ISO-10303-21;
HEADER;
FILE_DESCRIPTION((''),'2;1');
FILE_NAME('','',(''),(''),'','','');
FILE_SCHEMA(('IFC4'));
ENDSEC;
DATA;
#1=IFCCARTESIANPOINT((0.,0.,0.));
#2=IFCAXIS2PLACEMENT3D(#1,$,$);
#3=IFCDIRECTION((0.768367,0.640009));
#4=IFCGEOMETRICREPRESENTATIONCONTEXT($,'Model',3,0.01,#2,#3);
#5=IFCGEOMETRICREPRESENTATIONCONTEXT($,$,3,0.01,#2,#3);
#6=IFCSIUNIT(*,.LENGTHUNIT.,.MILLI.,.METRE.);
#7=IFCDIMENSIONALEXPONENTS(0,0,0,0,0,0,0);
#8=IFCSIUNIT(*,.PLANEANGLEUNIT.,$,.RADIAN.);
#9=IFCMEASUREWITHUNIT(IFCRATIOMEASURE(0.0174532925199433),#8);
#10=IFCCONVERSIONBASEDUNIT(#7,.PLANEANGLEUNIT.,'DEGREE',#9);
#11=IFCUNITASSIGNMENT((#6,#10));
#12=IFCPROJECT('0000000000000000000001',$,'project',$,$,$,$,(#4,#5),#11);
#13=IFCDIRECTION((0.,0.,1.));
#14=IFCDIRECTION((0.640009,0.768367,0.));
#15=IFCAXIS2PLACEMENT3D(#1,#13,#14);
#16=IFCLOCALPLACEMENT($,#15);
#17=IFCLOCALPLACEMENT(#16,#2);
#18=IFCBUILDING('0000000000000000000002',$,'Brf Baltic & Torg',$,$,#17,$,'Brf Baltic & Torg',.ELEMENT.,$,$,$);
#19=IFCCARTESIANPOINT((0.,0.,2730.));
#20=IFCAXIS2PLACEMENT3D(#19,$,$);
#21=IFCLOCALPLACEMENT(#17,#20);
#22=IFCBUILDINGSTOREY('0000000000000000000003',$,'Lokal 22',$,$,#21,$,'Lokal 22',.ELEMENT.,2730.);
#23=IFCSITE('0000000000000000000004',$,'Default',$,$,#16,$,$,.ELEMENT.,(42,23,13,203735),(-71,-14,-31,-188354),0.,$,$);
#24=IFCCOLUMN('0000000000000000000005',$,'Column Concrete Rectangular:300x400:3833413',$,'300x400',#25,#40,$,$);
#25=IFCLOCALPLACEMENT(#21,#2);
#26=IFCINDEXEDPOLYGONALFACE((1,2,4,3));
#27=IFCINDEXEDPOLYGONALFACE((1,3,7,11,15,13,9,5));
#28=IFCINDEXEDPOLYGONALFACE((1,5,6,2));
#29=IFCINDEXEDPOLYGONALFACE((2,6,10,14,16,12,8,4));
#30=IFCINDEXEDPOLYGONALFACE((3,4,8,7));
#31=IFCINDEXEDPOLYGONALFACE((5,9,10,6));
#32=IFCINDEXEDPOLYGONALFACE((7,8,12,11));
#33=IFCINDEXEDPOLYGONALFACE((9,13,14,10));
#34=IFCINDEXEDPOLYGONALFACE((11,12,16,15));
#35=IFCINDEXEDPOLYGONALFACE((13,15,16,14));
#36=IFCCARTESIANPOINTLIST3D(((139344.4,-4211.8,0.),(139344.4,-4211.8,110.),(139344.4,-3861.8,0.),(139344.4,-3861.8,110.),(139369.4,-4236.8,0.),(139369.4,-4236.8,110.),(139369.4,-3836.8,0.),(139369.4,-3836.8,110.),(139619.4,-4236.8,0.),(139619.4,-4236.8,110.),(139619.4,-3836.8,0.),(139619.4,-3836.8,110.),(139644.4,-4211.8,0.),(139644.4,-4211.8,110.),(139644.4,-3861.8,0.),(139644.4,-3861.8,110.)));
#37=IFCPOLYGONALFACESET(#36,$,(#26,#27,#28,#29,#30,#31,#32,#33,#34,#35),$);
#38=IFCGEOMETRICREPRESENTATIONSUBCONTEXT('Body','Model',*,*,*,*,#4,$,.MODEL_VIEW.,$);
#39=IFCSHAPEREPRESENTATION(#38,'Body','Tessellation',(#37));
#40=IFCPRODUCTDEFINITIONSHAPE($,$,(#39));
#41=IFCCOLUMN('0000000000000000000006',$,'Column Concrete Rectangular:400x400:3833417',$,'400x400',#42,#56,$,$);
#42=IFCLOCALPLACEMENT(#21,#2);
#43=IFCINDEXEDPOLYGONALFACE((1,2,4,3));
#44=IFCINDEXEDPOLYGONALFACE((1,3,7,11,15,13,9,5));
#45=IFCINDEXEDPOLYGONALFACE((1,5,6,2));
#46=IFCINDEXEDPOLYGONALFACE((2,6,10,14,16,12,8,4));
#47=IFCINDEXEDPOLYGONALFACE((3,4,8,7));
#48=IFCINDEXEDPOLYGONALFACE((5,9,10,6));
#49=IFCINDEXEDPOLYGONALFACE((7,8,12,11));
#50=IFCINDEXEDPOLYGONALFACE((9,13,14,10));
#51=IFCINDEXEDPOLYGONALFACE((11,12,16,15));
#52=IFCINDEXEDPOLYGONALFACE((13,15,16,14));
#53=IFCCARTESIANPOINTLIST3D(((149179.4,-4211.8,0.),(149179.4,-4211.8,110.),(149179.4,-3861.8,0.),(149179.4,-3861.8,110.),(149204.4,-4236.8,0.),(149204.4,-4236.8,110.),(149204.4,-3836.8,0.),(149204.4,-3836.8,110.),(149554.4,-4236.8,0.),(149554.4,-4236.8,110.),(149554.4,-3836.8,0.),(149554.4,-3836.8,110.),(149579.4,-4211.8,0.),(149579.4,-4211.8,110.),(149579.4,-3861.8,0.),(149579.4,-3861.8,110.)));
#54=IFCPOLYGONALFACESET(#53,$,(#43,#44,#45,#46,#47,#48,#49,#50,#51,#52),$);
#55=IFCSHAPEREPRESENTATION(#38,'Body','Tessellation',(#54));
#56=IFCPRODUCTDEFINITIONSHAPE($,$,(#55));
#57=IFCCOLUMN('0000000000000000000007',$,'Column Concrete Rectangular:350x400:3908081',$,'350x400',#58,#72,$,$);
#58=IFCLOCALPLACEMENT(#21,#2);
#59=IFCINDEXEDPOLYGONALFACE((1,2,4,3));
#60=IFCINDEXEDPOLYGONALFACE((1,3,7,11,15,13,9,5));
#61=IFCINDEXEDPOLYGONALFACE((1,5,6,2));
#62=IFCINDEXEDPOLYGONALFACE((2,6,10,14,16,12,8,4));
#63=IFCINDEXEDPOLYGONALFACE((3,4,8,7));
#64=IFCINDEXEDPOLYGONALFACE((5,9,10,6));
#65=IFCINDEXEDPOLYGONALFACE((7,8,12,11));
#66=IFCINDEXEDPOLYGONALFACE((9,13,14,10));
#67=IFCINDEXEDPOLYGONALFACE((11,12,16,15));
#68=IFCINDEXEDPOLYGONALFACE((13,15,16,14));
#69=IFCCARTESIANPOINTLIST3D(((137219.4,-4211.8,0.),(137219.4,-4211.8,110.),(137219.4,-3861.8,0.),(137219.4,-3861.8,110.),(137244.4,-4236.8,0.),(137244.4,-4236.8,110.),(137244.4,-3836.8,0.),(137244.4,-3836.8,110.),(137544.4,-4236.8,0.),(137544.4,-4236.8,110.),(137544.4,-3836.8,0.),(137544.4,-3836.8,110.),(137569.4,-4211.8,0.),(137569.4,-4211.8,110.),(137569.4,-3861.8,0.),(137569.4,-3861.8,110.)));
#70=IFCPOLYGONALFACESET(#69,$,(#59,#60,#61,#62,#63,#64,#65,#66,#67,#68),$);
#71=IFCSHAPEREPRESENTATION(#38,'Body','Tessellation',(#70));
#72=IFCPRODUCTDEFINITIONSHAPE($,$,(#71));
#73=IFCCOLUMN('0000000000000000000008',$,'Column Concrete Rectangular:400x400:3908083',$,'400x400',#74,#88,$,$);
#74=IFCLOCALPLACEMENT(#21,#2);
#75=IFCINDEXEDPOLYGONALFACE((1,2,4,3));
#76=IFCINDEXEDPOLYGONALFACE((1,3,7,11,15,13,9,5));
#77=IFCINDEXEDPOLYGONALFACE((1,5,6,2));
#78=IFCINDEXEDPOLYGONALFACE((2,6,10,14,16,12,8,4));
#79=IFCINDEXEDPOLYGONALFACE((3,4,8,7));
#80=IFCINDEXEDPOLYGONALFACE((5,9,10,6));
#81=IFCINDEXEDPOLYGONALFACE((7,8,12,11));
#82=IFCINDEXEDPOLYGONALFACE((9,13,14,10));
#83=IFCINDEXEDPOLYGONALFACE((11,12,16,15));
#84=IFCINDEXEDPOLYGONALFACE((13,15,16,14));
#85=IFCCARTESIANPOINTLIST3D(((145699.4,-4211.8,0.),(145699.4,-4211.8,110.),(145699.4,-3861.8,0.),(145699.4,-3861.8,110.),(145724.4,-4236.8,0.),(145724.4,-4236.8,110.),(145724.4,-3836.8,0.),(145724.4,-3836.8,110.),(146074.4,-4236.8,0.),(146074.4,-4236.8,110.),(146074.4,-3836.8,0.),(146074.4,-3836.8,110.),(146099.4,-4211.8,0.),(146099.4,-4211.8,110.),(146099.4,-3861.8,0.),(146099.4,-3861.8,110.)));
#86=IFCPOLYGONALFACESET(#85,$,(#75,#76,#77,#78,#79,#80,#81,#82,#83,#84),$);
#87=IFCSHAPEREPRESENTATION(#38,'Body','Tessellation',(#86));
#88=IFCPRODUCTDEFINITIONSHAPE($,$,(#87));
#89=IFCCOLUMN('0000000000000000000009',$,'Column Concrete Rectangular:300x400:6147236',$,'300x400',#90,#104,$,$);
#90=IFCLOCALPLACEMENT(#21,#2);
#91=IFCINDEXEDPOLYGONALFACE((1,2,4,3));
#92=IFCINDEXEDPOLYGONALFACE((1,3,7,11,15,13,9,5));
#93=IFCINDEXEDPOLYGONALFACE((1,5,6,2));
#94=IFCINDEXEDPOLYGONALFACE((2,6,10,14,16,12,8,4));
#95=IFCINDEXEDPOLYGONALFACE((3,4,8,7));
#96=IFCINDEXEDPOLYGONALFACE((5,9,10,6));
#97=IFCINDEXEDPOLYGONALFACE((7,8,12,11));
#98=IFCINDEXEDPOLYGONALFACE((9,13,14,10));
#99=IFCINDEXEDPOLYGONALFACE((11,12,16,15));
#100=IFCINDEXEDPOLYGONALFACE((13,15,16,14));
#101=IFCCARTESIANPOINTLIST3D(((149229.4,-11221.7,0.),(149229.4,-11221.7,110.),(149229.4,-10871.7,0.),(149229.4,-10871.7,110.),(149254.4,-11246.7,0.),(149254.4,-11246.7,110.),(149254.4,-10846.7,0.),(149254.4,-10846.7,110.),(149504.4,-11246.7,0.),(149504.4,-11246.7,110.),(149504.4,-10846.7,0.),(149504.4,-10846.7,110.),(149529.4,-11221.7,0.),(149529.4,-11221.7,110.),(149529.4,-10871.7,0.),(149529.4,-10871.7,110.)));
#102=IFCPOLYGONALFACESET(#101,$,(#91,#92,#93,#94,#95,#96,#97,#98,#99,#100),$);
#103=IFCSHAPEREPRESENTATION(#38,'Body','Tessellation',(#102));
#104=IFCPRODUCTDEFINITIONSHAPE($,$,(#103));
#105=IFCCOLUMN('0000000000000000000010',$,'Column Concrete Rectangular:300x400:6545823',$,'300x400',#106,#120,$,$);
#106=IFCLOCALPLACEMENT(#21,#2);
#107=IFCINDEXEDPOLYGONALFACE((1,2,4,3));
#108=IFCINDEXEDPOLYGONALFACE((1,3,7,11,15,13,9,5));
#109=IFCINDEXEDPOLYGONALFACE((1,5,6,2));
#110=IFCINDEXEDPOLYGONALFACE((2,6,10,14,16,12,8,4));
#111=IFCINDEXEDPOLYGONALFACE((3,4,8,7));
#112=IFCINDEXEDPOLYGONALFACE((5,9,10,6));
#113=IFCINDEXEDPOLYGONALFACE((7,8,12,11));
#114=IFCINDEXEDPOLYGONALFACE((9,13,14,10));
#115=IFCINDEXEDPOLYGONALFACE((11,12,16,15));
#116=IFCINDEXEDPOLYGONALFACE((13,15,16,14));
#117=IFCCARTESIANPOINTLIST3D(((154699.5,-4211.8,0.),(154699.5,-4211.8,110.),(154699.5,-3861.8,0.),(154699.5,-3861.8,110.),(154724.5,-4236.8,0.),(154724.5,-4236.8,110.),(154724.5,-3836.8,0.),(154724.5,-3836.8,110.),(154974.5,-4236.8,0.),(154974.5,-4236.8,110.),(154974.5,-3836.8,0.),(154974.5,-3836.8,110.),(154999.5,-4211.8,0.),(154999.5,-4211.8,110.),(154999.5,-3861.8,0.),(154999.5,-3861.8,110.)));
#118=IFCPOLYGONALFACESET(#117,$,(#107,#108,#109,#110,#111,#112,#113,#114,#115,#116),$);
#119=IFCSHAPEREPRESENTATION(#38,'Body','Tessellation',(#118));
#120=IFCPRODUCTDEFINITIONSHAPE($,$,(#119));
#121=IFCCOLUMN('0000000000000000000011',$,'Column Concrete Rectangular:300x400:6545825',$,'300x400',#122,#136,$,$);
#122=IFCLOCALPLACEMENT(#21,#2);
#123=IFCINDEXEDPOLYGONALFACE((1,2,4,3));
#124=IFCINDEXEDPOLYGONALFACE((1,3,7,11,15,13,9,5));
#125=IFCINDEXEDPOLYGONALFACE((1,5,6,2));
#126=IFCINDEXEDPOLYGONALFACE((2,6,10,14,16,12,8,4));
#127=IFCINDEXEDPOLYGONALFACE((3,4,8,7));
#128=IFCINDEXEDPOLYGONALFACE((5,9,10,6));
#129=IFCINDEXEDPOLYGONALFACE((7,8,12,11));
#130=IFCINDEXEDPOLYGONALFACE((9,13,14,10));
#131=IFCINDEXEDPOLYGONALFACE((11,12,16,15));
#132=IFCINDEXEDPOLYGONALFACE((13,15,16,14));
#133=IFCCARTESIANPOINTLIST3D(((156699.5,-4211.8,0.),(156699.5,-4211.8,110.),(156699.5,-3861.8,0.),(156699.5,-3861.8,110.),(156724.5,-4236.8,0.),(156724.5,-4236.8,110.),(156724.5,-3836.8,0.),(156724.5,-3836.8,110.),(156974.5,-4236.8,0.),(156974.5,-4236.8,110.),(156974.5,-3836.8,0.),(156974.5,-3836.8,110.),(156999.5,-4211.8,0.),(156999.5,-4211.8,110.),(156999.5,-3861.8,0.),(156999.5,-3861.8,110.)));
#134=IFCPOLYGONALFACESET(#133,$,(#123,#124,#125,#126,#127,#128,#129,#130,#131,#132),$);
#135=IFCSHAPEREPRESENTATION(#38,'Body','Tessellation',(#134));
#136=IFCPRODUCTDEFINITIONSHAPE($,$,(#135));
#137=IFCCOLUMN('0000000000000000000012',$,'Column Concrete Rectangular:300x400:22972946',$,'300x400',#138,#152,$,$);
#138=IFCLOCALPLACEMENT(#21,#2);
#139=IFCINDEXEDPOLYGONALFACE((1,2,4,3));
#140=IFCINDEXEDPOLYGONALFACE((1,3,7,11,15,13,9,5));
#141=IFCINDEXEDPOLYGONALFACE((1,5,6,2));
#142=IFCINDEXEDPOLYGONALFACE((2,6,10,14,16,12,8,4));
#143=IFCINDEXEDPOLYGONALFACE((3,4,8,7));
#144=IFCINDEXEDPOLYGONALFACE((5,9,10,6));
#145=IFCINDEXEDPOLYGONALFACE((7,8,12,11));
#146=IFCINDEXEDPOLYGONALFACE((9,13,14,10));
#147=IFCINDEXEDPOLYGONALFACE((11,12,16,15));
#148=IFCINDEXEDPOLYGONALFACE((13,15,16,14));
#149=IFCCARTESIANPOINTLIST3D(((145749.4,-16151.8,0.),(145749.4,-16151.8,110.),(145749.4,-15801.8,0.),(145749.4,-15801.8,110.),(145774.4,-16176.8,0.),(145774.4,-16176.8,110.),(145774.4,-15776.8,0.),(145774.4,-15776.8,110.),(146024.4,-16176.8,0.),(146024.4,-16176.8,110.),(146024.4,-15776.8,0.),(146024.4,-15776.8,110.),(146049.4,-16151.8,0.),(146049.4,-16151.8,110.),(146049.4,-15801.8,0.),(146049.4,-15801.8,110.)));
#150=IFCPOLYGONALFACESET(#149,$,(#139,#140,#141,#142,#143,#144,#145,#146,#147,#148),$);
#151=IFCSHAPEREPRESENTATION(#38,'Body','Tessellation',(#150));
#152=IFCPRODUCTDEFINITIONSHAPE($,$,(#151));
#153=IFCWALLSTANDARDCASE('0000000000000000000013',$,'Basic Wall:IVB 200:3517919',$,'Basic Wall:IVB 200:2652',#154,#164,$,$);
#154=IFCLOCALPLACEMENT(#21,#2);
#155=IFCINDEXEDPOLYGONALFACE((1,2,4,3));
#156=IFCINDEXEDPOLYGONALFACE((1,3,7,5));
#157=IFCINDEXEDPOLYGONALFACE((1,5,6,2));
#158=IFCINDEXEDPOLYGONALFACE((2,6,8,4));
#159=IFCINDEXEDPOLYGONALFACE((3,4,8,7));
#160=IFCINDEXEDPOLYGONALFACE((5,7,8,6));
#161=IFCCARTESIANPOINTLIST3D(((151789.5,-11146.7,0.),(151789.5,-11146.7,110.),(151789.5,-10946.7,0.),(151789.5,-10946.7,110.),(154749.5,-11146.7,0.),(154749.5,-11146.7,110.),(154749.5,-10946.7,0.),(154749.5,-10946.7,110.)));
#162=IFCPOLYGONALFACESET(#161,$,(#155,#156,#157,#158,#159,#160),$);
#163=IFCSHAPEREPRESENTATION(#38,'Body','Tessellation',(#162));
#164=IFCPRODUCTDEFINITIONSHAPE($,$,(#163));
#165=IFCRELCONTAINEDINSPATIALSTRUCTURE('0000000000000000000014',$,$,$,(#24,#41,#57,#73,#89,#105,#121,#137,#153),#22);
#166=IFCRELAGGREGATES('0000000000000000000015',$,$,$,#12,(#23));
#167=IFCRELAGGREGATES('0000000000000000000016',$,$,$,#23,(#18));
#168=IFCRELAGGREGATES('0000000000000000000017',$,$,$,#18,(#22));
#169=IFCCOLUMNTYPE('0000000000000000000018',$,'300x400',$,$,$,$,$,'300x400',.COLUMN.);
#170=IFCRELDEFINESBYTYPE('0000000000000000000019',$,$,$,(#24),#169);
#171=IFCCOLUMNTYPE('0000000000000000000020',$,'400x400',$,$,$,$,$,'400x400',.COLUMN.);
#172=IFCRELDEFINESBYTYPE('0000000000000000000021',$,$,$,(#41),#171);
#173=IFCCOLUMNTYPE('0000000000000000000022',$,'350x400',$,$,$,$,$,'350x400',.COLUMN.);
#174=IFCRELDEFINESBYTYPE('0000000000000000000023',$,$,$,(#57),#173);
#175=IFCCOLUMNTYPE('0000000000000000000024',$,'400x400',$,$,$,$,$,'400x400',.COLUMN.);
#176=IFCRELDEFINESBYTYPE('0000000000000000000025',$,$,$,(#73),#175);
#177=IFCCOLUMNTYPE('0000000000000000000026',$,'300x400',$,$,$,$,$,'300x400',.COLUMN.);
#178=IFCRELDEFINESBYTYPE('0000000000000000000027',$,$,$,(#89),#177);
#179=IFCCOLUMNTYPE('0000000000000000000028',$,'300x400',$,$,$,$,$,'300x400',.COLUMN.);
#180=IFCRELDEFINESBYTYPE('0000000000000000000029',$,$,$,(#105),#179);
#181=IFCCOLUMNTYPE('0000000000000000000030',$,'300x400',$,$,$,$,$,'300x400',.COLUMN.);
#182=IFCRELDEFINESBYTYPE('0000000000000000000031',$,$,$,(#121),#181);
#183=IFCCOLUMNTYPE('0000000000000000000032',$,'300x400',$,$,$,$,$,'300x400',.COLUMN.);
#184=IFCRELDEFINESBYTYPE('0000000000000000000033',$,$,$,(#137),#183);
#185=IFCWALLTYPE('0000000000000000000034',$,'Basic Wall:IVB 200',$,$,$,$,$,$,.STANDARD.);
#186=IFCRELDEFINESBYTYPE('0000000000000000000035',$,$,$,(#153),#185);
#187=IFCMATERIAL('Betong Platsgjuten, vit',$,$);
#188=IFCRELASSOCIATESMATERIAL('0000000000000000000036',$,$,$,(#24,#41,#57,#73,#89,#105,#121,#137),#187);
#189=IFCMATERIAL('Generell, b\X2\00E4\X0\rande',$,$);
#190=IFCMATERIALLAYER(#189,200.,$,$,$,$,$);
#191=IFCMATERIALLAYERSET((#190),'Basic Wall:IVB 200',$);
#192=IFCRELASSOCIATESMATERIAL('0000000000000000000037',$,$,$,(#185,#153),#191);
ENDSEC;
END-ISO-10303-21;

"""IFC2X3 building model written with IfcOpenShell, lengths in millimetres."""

from ifc_helpers import new_model, entity, si_unit, converted_unit, direction, frame, frame_2d, origin, place, context, subcontext, project, spatial, polyline, rectangle, outline, extrude, clip, halfspace, source, transform, mapped, material, layer, layer_set, layer_usage, type_object, type_shapes, element, save


model = new_model("IFC2X3")

# Units and contexts
model_context = context("Model", 3, precision=0.01, world=origin(), true_north=direction((0.768367, 0.640009)))
context_of_model = context(None, 3, precision=0.01, world=origin(), true_north=direction((0.768367, 0.640009)))
body_context = subcontext(model_context, "Body", "Model", "MODEL_VIEW")
ifc_project = project(units=[si_unit("LENGTHUNIT", "METRE", prefix="MILLI"), converted_unit("PLANEANGLEUNIT", "DEGREE", entity("IfcRatioMeasure", 0.0174532925199433), si_unit("PLANEANGLEUNIT", "RADIAN"), dimensions=[0, 0, 0, 0, 0, 0, 0])], contexts=[model_context, context_of_model])

# Site, building, storey
site_placement = place(None, frame((0.0, 0.0, 0.0), z_axis=(0.0, 0.0, 1.0), x_axis=(0.640009, 0.768367, 0.0)))
site = spatial("IfcSite", under=ifc_project, at=site_placement, Name="Default", CompositionType="ELEMENT", RefLatitude=(42, 23, 13, 203735), RefLongitude=(-71, -14, -31, -188354), RefElevation=0.0)
building_placement = place(site_placement, origin())
building = spatial("IfcBuilding", under=site, at=building_placement, Name="Brf Baltic & Torg", LongName="Brf Baltic & Torg", CompositionType="ELEMENT")
storey_placement = place(building_placement, frame((0.0, 0.0, 2730.0)))
storey = spatial("IfcBuildingStorey", under=building, at=storey_placement, Name="Lokal 22", LongName="Lokal 22", CompositionType="ELEMENT", Elevation=2730.0)

# Columns
ifc_material_1 = material(Name="Betong Platsgjuten, vit")
column_type_1 = type_object("IfcColumnType", Name="300x400", ElementType="300x400", PredefinedType="COLUMN")
shared_shape_1 = source(origin(), body_context, "Body", "SweptSolid", [
    extrude(outline(polyline([(-175.0, -150.0), (175.0, -150.0), (200.0, -125.0), (200.0, 125.0), (175.0, 150.0), (-175.0, 150.0), (-200.0, 125.0), (-200.0, -125.0), (-175.0, -150.0)])), frame((0.0, 0.0, 2730.0), z_axis=(0.0, 0.0, 1.0), x_axis=(0.0, -1.0, 0.0)), (0.0, 0.0, 1.0), 110.0),
])
type_shapes(column_type_1, [shared_shape_1])
column_1_placement = place(storey_placement, frame((139494.4, -4036.8, -2730.0)))
element("IfcColumn", 1, at=column_1_placement, inside=storey, type_object=column_type_1, material=ifc_material_1, Name="Column Concrete Rectangular:300x400:3833413", ObjectType="300x400", context=body_context, shape_type="MappedRepresentation", body=[
    mapped(shared_shape_1, transform((0.0, 0.0, 0.0), scale=1.0)),
])
column_type_2 = type_object("IfcColumnType", Name="400x400", ElementType="400x400", PredefinedType="COLUMN")
shared_shape_2 = source(origin(), body_context, "Body", "SweptSolid", [
    extrude(outline(polyline([(-175.0, -200.0), (175.0, -200.0), (200.0, -175.0), (200.0, 175.0), (175.0, 200.0), (-175.0, 200.0), (-200.0, 175.0), (-200.0, -175.0), (-175.0, -200.0)])), frame((0.0, 0.0, 2730.0), z_axis=(0.0, 0.0, 1.0), x_axis=(0.0, -1.0, 0.0)), (0.0, 0.0, 1.0), 110.0),
])
type_shapes(column_type_2, [shared_shape_2])
column_2_placement = place(storey_placement, frame((149379.4, -4036.8, -2730.0)))
element("IfcColumn", 2, at=column_2_placement, inside=storey, type_object=column_type_2, material=ifc_material_1, Name="Column Concrete Rectangular:400x400:3833417", ObjectType="400x400", context=body_context, shape_type="MappedRepresentation", body=[
    mapped(shared_shape_2, transform((0.0, 0.0, 0.0), scale=1.0)),
])
column_type_3 = type_object("IfcColumnType", Name="350x400", ElementType="350x400", PredefinedType="COLUMN")
shared_shape_3 = source(origin(), body_context, "Body", "SweptSolid", [
    extrude(outline(polyline([(-175.0, -175.0), (175.0, -175.0), (200.0, -150.0), (200.0, 150.0), (175.0, 175.0), (-175.0, 175.0), (-200.0, 150.0), (-200.0, -150.0), (-175.0, -175.0)])), frame((0.0, 0.0, 2730.0), z_axis=(0.0, 0.0, 1.0), x_axis=(0.0, -1.0, 0.0)), (0.0, 0.0, 1.0), 110.0),
])
type_shapes(column_type_3, [shared_shape_3])
column_3_placement = place(storey_placement, frame((137394.4, -4036.8, -2730.0)))
element("IfcColumn", 3, at=column_3_placement, inside=storey, type_object=column_type_3, material=ifc_material_1, Name="Column Concrete Rectangular:350x400:3908081", ObjectType="350x400", context=body_context, shape_type="MappedRepresentation", body=[
    mapped(shared_shape_3, transform((0.0, 0.0, 0.0), scale=1.0)),
])
column_type_4 = type_object("IfcColumnType", Name="400x400", ElementType="400x400", PredefinedType="COLUMN")
shared_shape_4 = source(origin(), body_context, "Body", "SweptSolid", [
    extrude(outline(polyline([(-175.0, -200.0), (175.0, -200.0), (200.0, -175.0), (200.0, 175.0), (175.0, 200.0), (-175.0, 200.0), (-200.0, 175.0), (-200.0, -175.0), (-175.0, -200.0)])), frame((0.0, 0.0, 2730.0), z_axis=(0.0, 0.0, 1.0), x_axis=(0.0, -1.0, 0.0)), (0.0, 0.0, 1.0), 110.0),
])
type_shapes(column_type_4, [shared_shape_4])
column_4_placement = place(storey_placement, frame((145899.4, -4036.8, -2730.0)))
element("IfcColumn", 4, at=column_4_placement, inside=storey, type_object=column_type_4, material=ifc_material_1, Name="Column Concrete Rectangular:400x400:3908083", ObjectType="400x400", context=body_context, shape_type="MappedRepresentation", body=[
    mapped(shared_shape_4, transform((0.0, 0.0, 0.0), scale=1.0)),
])
column_type_5 = type_object("IfcColumnType", Name="300x400", ElementType="300x400", PredefinedType="COLUMN")
shared_shape_5 = source(origin(), body_context, "Body", "SweptSolid", [
    extrude(outline(polyline([(-175.0, -150.0), (175.0, -150.0), (200.0, -125.0), (200.0, 125.0), (175.0, 150.0), (-175.0, 150.0), (-200.0, 125.0), (-200.0, -125.0), (-175.0, -150.0)])), frame((0.0, 0.0, 2730.0), z_axis=(0.0, 0.0, 1.0), x_axis=(0.0, -1.0, 0.0)), (0.0, 0.0, 1.0), 110.0),
])
type_shapes(column_type_5, [shared_shape_5])
column_5_placement = place(storey_placement, frame((149379.4, -11046.7, -2730.0)))
element("IfcColumn", 5, at=column_5_placement, inside=storey, type_object=column_type_5, material=ifc_material_1, Name="Column Concrete Rectangular:300x400:6147236", ObjectType="300x400", context=body_context, shape_type="MappedRepresentation", body=[
    mapped(shared_shape_5, transform((0.0, 0.0, 0.0), scale=1.0)),
])
column_type_6 = type_object("IfcColumnType", Name="300x400", ElementType="300x400", PredefinedType="COLUMN")
shared_shape_6 = source(origin(), body_context, "Body", "SweptSolid", [
    extrude(outline(polyline([(-175.0, -150.0), (175.0, -150.0), (200.0, -125.0), (200.0, 125.0), (175.0, 150.0), (-175.0, 150.0), (-200.0, 125.0), (-200.0, -125.0), (-175.0, -150.0)])), frame((0.0, 0.0, 2730.0), z_axis=(0.0, 0.0, 1.0), x_axis=(0.0, -1.0, 0.0)), (0.0, 0.0, 1.0), 110.0),
])
type_shapes(column_type_6, [shared_shape_6])
column_6_placement = place(storey_placement, frame((154849.5, -4036.8, -2730.0)))
element("IfcColumn", 6, at=column_6_placement, inside=storey, type_object=column_type_6, material=ifc_material_1, Name="Column Concrete Rectangular:300x400:6545823", ObjectType="300x400", context=body_context, shape_type="MappedRepresentation", body=[
    mapped(shared_shape_6, transform((0.0, 0.0, 0.0), scale=1.0)),
])
column_type_7 = type_object("IfcColumnType", Name="300x400", ElementType="300x400", PredefinedType="COLUMN")
shared_shape_7 = source(origin(), body_context, "Body", "SweptSolid", [
    extrude(outline(polyline([(-175.0, -150.0), (175.0, -150.0), (200.0, -125.0), (200.0, 125.0), (175.0, 150.0), (-175.0, 150.0), (-200.0, 125.0), (-200.0, -125.0), (-175.0, -150.0)])), frame((0.0, 0.0, 2730.0), z_axis=(0.0, 0.0, 1.0), x_axis=(0.0, -1.0, 0.0)), (0.0, 0.0, 1.0), 110.0),
])
type_shapes(column_type_7, [shared_shape_7])
column_7_placement = place(storey_placement, frame((156849.5, -4036.8, -2730.0)))
element("IfcColumn", 7, at=column_7_placement, inside=storey, type_object=column_type_7, material=ifc_material_1, Name="Column Concrete Rectangular:300x400:6545825", ObjectType="300x400", context=body_context, shape_type="MappedRepresentation", body=[
    mapped(shared_shape_7, transform((0.0, 0.0, 0.0), scale=1.0)),
])
column_type_8 = type_object("IfcColumnType", Name="300x400", ElementType="300x400", PredefinedType="COLUMN")
shared_shape_8 = source(origin(), body_context, "Body", "SweptSolid", [
    extrude(outline(polyline([(-175.0, -150.0), (175.0, -150.0), (200.0, -125.0), (200.0, 125.0), (175.0, 150.0), (-175.0, 150.0), (-200.0, 125.0), (-200.0, -125.0), (-175.0, -150.0)])), frame((0.0, 0.0, 2730.0), z_axis=(0.0, 0.0, 1.0), x_axis=(0.0, -1.0, 0.0)), (0.0, 0.0, 1.0), 110.0),
])
type_shapes(column_type_8, [shared_shape_8])
column_8_placement = place(storey_placement, frame((145899.4, -15976.8, -2730.0)))
element("IfcColumn", 8, at=column_8_placement, inside=storey, type_object=column_type_8, material=ifc_material_1, Name="Column Concrete Rectangular:300x400:22972946", ObjectType="300x400", context=body_context, shape_type="MappedRepresentation", body=[
    mapped(shared_shape_8, transform((0.0, 0.0, 0.0), scale=1.0)),
])

# Wall
ifc_material_2 = material(Name="Generell, bärande")
ifc_layer_1 = layer(ifc_material_2, 200.0)
ifc_layer_set_1 = layer_set([ifc_layer_1], Name="Basic Wall:IVB 200")
ifc_layer_usage_1 = layer_usage(ifc_layer_set_1, "AXIS2", "NEGATIVE", 100.0)
wall_type_1 = type_object("IfcWallType", Name="Basic Wall:IVB 200", PredefinedType="STANDARD", material=ifc_layer_set_1)
wall_1_placement = place(storey_placement, frame((151789.5, -11046.7, 0.0)))
element("IfcWallStandardCase", 9, at=wall_1_placement, inside=storey, type_object=wall_type_1, material=ifc_layer_usage_1, Name="Basic Wall:IVB 200:3517919", ObjectType="Basic Wall:IVB 200:2652", context=body_context, shape_type="Clipping", body=[
    clip(extrude(rectangle(XDim=2960.0, YDim=200.0, at=frame_2d((1480.0, 0.0), x_axis=(-1.0, 0.0))), origin(), (0.0, 0.0, 1.0), 110.0), halfspace(frame((0.0, 0.0, -1080.0)), True)),
])

save(model, "model.ifc")
